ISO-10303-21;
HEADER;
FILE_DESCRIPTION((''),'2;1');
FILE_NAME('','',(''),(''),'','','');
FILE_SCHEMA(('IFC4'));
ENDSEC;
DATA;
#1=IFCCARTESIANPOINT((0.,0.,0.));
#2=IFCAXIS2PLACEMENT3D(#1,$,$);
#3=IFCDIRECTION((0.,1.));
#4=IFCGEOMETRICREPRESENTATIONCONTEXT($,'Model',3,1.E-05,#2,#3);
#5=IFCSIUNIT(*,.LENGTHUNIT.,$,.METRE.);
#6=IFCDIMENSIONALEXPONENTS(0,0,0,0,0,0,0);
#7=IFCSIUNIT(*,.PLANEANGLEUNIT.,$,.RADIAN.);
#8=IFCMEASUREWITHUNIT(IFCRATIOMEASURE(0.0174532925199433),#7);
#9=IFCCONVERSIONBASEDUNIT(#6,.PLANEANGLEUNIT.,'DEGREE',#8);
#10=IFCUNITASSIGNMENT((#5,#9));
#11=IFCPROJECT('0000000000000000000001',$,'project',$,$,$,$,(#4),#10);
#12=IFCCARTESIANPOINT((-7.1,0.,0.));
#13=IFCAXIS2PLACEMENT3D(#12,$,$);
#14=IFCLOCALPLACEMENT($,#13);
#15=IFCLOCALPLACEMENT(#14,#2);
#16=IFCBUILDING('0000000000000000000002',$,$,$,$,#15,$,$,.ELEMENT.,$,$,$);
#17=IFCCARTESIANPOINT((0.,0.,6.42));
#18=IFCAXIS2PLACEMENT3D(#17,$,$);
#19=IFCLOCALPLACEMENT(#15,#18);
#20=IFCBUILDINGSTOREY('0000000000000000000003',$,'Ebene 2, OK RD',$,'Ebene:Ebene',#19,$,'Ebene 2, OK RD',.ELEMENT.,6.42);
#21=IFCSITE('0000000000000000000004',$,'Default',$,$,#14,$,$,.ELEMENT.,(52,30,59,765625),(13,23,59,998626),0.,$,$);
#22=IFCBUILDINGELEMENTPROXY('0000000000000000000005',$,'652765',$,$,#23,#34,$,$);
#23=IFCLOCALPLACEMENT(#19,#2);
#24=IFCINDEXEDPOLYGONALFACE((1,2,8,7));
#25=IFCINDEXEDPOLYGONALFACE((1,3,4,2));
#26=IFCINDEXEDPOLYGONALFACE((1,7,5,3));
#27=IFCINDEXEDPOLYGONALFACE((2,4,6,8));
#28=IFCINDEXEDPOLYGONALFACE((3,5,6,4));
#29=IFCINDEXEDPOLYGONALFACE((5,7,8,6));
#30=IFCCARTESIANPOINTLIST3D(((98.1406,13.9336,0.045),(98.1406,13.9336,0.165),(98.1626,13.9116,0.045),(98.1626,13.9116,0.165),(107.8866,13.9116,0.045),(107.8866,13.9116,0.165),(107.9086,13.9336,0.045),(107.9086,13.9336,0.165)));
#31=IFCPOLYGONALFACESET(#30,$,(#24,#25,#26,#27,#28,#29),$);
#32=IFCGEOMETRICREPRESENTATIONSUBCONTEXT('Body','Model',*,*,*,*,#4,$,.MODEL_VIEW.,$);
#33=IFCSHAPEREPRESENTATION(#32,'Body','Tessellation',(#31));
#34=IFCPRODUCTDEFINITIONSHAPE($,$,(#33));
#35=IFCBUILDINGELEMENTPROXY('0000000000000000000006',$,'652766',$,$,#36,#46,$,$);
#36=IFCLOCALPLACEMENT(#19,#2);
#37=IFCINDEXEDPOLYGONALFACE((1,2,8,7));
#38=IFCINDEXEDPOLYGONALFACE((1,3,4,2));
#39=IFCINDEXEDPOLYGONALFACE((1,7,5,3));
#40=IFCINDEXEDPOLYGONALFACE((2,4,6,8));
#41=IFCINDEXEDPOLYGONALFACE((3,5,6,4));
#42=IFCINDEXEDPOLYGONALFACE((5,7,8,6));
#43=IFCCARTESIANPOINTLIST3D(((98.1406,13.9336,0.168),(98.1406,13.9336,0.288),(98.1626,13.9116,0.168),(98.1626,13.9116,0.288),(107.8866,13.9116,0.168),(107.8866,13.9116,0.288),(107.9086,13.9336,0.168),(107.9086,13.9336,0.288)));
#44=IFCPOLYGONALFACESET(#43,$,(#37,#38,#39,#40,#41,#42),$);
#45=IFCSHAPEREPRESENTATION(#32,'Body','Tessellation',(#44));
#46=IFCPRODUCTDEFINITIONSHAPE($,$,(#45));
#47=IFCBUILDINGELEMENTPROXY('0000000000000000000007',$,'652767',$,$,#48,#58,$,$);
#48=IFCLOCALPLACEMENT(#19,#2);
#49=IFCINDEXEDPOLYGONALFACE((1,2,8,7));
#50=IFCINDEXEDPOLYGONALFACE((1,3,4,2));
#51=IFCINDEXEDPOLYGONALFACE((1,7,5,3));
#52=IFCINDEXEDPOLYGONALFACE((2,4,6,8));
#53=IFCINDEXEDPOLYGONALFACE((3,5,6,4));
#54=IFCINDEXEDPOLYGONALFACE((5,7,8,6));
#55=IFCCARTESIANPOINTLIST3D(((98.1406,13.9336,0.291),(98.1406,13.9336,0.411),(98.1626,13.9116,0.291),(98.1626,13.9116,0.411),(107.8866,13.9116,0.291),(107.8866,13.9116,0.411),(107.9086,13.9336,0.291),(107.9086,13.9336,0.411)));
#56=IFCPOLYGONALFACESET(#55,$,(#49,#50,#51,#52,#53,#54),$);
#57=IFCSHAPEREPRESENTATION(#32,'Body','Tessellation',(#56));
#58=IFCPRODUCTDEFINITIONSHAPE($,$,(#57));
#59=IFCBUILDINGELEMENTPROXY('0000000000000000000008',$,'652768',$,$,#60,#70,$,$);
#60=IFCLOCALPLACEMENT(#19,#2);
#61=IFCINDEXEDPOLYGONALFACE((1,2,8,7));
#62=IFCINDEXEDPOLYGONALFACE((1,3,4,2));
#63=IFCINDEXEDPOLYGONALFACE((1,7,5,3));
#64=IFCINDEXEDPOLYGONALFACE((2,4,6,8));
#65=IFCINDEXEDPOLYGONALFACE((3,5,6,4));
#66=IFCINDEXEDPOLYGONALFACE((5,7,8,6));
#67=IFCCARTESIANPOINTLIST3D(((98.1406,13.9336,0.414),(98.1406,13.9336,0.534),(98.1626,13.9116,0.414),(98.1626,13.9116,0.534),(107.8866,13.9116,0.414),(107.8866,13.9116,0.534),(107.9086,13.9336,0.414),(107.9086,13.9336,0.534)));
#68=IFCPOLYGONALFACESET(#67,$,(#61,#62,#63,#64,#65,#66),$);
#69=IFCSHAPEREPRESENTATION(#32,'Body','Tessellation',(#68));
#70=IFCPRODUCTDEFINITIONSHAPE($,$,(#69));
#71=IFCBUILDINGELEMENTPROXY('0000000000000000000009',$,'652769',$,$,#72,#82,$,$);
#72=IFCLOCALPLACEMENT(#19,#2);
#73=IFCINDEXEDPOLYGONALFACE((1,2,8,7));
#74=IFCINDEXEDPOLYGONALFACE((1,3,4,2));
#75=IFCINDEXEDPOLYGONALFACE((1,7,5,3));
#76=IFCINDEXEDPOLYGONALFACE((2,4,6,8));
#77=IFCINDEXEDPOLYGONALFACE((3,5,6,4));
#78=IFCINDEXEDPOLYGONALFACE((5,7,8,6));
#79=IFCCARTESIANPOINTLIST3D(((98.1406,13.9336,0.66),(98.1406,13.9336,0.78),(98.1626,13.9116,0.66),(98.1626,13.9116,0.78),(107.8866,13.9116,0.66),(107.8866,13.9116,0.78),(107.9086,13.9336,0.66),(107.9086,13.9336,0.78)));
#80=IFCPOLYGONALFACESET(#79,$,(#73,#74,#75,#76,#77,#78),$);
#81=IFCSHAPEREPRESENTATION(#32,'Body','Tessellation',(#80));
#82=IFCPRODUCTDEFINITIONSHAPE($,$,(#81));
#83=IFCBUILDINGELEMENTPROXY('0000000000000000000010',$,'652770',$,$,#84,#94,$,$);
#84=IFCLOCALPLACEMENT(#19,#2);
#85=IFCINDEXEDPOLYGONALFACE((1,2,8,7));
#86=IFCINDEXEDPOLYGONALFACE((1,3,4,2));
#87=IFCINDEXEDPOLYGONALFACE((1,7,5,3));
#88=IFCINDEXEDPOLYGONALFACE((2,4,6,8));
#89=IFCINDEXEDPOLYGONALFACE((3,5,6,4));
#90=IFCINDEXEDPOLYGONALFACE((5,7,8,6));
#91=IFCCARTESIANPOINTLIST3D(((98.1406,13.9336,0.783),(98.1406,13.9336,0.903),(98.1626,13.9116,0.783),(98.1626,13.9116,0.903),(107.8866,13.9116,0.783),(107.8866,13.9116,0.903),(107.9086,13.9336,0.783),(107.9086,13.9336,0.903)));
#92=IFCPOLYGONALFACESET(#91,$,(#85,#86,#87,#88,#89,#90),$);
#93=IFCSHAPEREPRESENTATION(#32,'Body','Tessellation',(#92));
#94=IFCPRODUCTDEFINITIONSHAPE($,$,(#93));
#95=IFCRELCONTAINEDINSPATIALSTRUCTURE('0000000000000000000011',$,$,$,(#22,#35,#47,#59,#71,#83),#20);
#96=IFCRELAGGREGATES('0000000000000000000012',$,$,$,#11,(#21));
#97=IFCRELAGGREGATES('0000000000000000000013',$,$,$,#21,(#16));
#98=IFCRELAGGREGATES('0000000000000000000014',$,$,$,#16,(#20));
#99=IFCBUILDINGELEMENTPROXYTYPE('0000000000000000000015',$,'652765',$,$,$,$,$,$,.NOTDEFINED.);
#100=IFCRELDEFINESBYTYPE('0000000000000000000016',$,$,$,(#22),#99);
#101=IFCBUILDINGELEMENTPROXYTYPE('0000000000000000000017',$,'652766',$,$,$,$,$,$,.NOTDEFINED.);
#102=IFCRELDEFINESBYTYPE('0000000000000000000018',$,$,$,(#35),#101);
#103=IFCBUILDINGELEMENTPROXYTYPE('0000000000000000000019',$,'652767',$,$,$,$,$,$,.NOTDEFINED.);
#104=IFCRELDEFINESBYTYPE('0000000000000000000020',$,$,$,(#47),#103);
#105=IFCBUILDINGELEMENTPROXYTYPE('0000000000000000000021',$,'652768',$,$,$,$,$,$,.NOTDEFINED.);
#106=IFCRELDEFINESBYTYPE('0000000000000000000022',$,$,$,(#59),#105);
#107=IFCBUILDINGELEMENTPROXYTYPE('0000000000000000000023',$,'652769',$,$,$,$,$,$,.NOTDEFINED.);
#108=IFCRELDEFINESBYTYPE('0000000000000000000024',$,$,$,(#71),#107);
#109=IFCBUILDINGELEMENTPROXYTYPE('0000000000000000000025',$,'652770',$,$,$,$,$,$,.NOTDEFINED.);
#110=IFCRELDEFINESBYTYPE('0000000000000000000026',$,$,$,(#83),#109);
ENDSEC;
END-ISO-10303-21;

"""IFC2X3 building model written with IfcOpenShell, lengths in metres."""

from ifc_helpers import new_model, entity, si_unit, converted_unit, direction, frame, origin, place, context, subcontext, project, spatial, polyline, outline, extrude, type_object, element, save


model = new_model("IFC2X3")

# Units and contexts
model_context = context("Model", 3, precision=1e-05, world=origin(), true_north=direction((0.0, 1.0)))
body_context = subcontext(model_context, "Body", "Model", "MODEL_VIEW")
ifc_project = project(units=[si_unit("LENGTHUNIT", "METRE"), converted_unit("PLANEANGLEUNIT", "DEGREE", entity("IfcRatioMeasure", 0.0174532925199433), si_unit("PLANEANGLEUNIT", "RADIAN"), dimensions=[0, 0, 0, 0, 0, 0, 0])], contexts=[model_context])

# Site, building, storey
site_placement = place(None, frame((-7.1, 0.0, 0.0)))
site = spatial("IfcSite", under=ifc_project, at=site_placement, Name="Default", CompositionType="ELEMENT", RefLatitude=(52, 30, 59, 765625), RefLongitude=(13, 23, 59, 998626), RefElevation=0.0)
building_placement = place(site_placement, origin())
building = spatial("IfcBuilding", under=site, at=building_placement, CompositionType="ELEMENT")
storey_placement = place(building_placement, frame((0.0, 0.0, 6.42)))
storey = spatial("IfcBuildingStorey", under=building, at=storey_placement, Name="Ebene 2, OK RD", ObjectType="Ebene:Ebene", LongName="Ebene 2, OK RD", CompositionType="ELEMENT", Elevation=6.42)

# Building element proxies
building_element_proxy_type_1 = type_object("IfcBuildingElementProxyType", Name="652765", PredefinedType="NOTDEFINED")
proxy_1_placement = place(storey_placement, origin())
element("IfcBuildingElementProxy", 1, at=proxy_1_placement, inside=storey, type_object=building_element_proxy_type_1, Name="652765", context=body_context, shape_type="SweptSolid", body=[
    extrude(outline(polyline([(-4.862, -0.011), (4.862, -0.011), (4.884, 0.011), (-4.884, 0.011), (-4.862, -0.011)])), frame((103.0246, 13.9226, 0.045)), (0.0, 0.0, 1.0), 0.12),
])
building_element_proxy_type_2 = type_object("IfcBuildingElementProxyType", Name="652766", PredefinedType="NOTDEFINED")
proxy_2_placement = place(storey_placement, origin())
element("IfcBuildingElementProxy", 2, at=proxy_2_placement, inside=storey, type_object=building_element_proxy_type_2, Name="652766", context=body_context, shape_type="SweptSolid", body=[
    extrude(outline(polyline([(-4.862, -0.011), (4.862, -0.011), (4.884, 0.011), (-4.884, 0.011), (-4.862, -0.011)])), frame((103.0246, 13.9226, 0.168)), (0.0, 0.0, 1.0), 0.12),
])
building_element_proxy_type_3 = type_object("IfcBuildingElementProxyType", Name="652767", PredefinedType="NOTDEFINED")
proxy_3_placement = place(storey_placement, origin())
element("IfcBuildingElementProxy", 3, at=proxy_3_placement, inside=storey, type_object=building_element_proxy_type_3, Name="652767", context=body_context, shape_type="SweptSolid", body=[
    extrude(outline(polyline([(-4.862, -0.011), (4.862, -0.011), (4.884, 0.011), (-4.884, 0.011), (-4.862, -0.011)])), frame((103.0246, 13.9226, 0.291)), (0.0, 0.0, 1.0), 0.12),
])
building_element_proxy_type_4 = type_object("IfcBuildingElementProxyType", Name="652768", PredefinedType="NOTDEFINED")
proxy_4_placement = place(storey_placement, origin())
element("IfcBuildingElementProxy", 4, at=proxy_4_placement, inside=storey, type_object=building_element_proxy_type_4, Name="652768", context=body_context, shape_type="SweptSolid", body=[
    extrude(outline(polyline([(-4.862, -0.011), (4.862, -0.011), (4.884, 0.011), (-4.884, 0.011), (-4.862, -0.011)])), frame((103.0246, 13.9226, 0.414)), (0.0, 0.0, 1.0), 0.12),
])
building_element_proxy_type_5 = type_object("IfcBuildingElementProxyType", Name="652769", PredefinedType="NOTDEFINED")
proxy_5_placement = place(storey_placement, origin())
element("IfcBuildingElementProxy", 5, at=proxy_5_placement, inside=storey, type_object=building_element_proxy_type_5, Name="652769", context=body_context, shape_type="SweptSolid", body=[
    extrude(outline(polyline([(-4.862, -0.011), (4.862, -0.011), (4.884, 0.011), (-4.884, 0.011), (-4.862, -0.011)])), frame((103.0246, 13.9226, 0.66)), (0.0, 0.0, 1.0), 0.12),
])
building_element_proxy_type_6 = type_object("IfcBuildingElementProxyType", Name="652770", PredefinedType="NOTDEFINED")
proxy_6_placement = place(storey_placement, origin())
element("IfcBuildingElementProxy", 6, at=proxy_6_placement, inside=storey, type_object=building_element_proxy_type_6, Name="652770", context=body_context, shape_type="SweptSolid", body=[
    extrude(outline(polyline([(-4.862, -0.011), (4.862, -0.011), (4.884, 0.011), (-4.884, 0.011), (-4.862, -0.011)])), frame((103.0246, 13.9226, 0.783)), (0.0, 0.0, 1.0), 0.12),
])

save(model, "model.ifc")
